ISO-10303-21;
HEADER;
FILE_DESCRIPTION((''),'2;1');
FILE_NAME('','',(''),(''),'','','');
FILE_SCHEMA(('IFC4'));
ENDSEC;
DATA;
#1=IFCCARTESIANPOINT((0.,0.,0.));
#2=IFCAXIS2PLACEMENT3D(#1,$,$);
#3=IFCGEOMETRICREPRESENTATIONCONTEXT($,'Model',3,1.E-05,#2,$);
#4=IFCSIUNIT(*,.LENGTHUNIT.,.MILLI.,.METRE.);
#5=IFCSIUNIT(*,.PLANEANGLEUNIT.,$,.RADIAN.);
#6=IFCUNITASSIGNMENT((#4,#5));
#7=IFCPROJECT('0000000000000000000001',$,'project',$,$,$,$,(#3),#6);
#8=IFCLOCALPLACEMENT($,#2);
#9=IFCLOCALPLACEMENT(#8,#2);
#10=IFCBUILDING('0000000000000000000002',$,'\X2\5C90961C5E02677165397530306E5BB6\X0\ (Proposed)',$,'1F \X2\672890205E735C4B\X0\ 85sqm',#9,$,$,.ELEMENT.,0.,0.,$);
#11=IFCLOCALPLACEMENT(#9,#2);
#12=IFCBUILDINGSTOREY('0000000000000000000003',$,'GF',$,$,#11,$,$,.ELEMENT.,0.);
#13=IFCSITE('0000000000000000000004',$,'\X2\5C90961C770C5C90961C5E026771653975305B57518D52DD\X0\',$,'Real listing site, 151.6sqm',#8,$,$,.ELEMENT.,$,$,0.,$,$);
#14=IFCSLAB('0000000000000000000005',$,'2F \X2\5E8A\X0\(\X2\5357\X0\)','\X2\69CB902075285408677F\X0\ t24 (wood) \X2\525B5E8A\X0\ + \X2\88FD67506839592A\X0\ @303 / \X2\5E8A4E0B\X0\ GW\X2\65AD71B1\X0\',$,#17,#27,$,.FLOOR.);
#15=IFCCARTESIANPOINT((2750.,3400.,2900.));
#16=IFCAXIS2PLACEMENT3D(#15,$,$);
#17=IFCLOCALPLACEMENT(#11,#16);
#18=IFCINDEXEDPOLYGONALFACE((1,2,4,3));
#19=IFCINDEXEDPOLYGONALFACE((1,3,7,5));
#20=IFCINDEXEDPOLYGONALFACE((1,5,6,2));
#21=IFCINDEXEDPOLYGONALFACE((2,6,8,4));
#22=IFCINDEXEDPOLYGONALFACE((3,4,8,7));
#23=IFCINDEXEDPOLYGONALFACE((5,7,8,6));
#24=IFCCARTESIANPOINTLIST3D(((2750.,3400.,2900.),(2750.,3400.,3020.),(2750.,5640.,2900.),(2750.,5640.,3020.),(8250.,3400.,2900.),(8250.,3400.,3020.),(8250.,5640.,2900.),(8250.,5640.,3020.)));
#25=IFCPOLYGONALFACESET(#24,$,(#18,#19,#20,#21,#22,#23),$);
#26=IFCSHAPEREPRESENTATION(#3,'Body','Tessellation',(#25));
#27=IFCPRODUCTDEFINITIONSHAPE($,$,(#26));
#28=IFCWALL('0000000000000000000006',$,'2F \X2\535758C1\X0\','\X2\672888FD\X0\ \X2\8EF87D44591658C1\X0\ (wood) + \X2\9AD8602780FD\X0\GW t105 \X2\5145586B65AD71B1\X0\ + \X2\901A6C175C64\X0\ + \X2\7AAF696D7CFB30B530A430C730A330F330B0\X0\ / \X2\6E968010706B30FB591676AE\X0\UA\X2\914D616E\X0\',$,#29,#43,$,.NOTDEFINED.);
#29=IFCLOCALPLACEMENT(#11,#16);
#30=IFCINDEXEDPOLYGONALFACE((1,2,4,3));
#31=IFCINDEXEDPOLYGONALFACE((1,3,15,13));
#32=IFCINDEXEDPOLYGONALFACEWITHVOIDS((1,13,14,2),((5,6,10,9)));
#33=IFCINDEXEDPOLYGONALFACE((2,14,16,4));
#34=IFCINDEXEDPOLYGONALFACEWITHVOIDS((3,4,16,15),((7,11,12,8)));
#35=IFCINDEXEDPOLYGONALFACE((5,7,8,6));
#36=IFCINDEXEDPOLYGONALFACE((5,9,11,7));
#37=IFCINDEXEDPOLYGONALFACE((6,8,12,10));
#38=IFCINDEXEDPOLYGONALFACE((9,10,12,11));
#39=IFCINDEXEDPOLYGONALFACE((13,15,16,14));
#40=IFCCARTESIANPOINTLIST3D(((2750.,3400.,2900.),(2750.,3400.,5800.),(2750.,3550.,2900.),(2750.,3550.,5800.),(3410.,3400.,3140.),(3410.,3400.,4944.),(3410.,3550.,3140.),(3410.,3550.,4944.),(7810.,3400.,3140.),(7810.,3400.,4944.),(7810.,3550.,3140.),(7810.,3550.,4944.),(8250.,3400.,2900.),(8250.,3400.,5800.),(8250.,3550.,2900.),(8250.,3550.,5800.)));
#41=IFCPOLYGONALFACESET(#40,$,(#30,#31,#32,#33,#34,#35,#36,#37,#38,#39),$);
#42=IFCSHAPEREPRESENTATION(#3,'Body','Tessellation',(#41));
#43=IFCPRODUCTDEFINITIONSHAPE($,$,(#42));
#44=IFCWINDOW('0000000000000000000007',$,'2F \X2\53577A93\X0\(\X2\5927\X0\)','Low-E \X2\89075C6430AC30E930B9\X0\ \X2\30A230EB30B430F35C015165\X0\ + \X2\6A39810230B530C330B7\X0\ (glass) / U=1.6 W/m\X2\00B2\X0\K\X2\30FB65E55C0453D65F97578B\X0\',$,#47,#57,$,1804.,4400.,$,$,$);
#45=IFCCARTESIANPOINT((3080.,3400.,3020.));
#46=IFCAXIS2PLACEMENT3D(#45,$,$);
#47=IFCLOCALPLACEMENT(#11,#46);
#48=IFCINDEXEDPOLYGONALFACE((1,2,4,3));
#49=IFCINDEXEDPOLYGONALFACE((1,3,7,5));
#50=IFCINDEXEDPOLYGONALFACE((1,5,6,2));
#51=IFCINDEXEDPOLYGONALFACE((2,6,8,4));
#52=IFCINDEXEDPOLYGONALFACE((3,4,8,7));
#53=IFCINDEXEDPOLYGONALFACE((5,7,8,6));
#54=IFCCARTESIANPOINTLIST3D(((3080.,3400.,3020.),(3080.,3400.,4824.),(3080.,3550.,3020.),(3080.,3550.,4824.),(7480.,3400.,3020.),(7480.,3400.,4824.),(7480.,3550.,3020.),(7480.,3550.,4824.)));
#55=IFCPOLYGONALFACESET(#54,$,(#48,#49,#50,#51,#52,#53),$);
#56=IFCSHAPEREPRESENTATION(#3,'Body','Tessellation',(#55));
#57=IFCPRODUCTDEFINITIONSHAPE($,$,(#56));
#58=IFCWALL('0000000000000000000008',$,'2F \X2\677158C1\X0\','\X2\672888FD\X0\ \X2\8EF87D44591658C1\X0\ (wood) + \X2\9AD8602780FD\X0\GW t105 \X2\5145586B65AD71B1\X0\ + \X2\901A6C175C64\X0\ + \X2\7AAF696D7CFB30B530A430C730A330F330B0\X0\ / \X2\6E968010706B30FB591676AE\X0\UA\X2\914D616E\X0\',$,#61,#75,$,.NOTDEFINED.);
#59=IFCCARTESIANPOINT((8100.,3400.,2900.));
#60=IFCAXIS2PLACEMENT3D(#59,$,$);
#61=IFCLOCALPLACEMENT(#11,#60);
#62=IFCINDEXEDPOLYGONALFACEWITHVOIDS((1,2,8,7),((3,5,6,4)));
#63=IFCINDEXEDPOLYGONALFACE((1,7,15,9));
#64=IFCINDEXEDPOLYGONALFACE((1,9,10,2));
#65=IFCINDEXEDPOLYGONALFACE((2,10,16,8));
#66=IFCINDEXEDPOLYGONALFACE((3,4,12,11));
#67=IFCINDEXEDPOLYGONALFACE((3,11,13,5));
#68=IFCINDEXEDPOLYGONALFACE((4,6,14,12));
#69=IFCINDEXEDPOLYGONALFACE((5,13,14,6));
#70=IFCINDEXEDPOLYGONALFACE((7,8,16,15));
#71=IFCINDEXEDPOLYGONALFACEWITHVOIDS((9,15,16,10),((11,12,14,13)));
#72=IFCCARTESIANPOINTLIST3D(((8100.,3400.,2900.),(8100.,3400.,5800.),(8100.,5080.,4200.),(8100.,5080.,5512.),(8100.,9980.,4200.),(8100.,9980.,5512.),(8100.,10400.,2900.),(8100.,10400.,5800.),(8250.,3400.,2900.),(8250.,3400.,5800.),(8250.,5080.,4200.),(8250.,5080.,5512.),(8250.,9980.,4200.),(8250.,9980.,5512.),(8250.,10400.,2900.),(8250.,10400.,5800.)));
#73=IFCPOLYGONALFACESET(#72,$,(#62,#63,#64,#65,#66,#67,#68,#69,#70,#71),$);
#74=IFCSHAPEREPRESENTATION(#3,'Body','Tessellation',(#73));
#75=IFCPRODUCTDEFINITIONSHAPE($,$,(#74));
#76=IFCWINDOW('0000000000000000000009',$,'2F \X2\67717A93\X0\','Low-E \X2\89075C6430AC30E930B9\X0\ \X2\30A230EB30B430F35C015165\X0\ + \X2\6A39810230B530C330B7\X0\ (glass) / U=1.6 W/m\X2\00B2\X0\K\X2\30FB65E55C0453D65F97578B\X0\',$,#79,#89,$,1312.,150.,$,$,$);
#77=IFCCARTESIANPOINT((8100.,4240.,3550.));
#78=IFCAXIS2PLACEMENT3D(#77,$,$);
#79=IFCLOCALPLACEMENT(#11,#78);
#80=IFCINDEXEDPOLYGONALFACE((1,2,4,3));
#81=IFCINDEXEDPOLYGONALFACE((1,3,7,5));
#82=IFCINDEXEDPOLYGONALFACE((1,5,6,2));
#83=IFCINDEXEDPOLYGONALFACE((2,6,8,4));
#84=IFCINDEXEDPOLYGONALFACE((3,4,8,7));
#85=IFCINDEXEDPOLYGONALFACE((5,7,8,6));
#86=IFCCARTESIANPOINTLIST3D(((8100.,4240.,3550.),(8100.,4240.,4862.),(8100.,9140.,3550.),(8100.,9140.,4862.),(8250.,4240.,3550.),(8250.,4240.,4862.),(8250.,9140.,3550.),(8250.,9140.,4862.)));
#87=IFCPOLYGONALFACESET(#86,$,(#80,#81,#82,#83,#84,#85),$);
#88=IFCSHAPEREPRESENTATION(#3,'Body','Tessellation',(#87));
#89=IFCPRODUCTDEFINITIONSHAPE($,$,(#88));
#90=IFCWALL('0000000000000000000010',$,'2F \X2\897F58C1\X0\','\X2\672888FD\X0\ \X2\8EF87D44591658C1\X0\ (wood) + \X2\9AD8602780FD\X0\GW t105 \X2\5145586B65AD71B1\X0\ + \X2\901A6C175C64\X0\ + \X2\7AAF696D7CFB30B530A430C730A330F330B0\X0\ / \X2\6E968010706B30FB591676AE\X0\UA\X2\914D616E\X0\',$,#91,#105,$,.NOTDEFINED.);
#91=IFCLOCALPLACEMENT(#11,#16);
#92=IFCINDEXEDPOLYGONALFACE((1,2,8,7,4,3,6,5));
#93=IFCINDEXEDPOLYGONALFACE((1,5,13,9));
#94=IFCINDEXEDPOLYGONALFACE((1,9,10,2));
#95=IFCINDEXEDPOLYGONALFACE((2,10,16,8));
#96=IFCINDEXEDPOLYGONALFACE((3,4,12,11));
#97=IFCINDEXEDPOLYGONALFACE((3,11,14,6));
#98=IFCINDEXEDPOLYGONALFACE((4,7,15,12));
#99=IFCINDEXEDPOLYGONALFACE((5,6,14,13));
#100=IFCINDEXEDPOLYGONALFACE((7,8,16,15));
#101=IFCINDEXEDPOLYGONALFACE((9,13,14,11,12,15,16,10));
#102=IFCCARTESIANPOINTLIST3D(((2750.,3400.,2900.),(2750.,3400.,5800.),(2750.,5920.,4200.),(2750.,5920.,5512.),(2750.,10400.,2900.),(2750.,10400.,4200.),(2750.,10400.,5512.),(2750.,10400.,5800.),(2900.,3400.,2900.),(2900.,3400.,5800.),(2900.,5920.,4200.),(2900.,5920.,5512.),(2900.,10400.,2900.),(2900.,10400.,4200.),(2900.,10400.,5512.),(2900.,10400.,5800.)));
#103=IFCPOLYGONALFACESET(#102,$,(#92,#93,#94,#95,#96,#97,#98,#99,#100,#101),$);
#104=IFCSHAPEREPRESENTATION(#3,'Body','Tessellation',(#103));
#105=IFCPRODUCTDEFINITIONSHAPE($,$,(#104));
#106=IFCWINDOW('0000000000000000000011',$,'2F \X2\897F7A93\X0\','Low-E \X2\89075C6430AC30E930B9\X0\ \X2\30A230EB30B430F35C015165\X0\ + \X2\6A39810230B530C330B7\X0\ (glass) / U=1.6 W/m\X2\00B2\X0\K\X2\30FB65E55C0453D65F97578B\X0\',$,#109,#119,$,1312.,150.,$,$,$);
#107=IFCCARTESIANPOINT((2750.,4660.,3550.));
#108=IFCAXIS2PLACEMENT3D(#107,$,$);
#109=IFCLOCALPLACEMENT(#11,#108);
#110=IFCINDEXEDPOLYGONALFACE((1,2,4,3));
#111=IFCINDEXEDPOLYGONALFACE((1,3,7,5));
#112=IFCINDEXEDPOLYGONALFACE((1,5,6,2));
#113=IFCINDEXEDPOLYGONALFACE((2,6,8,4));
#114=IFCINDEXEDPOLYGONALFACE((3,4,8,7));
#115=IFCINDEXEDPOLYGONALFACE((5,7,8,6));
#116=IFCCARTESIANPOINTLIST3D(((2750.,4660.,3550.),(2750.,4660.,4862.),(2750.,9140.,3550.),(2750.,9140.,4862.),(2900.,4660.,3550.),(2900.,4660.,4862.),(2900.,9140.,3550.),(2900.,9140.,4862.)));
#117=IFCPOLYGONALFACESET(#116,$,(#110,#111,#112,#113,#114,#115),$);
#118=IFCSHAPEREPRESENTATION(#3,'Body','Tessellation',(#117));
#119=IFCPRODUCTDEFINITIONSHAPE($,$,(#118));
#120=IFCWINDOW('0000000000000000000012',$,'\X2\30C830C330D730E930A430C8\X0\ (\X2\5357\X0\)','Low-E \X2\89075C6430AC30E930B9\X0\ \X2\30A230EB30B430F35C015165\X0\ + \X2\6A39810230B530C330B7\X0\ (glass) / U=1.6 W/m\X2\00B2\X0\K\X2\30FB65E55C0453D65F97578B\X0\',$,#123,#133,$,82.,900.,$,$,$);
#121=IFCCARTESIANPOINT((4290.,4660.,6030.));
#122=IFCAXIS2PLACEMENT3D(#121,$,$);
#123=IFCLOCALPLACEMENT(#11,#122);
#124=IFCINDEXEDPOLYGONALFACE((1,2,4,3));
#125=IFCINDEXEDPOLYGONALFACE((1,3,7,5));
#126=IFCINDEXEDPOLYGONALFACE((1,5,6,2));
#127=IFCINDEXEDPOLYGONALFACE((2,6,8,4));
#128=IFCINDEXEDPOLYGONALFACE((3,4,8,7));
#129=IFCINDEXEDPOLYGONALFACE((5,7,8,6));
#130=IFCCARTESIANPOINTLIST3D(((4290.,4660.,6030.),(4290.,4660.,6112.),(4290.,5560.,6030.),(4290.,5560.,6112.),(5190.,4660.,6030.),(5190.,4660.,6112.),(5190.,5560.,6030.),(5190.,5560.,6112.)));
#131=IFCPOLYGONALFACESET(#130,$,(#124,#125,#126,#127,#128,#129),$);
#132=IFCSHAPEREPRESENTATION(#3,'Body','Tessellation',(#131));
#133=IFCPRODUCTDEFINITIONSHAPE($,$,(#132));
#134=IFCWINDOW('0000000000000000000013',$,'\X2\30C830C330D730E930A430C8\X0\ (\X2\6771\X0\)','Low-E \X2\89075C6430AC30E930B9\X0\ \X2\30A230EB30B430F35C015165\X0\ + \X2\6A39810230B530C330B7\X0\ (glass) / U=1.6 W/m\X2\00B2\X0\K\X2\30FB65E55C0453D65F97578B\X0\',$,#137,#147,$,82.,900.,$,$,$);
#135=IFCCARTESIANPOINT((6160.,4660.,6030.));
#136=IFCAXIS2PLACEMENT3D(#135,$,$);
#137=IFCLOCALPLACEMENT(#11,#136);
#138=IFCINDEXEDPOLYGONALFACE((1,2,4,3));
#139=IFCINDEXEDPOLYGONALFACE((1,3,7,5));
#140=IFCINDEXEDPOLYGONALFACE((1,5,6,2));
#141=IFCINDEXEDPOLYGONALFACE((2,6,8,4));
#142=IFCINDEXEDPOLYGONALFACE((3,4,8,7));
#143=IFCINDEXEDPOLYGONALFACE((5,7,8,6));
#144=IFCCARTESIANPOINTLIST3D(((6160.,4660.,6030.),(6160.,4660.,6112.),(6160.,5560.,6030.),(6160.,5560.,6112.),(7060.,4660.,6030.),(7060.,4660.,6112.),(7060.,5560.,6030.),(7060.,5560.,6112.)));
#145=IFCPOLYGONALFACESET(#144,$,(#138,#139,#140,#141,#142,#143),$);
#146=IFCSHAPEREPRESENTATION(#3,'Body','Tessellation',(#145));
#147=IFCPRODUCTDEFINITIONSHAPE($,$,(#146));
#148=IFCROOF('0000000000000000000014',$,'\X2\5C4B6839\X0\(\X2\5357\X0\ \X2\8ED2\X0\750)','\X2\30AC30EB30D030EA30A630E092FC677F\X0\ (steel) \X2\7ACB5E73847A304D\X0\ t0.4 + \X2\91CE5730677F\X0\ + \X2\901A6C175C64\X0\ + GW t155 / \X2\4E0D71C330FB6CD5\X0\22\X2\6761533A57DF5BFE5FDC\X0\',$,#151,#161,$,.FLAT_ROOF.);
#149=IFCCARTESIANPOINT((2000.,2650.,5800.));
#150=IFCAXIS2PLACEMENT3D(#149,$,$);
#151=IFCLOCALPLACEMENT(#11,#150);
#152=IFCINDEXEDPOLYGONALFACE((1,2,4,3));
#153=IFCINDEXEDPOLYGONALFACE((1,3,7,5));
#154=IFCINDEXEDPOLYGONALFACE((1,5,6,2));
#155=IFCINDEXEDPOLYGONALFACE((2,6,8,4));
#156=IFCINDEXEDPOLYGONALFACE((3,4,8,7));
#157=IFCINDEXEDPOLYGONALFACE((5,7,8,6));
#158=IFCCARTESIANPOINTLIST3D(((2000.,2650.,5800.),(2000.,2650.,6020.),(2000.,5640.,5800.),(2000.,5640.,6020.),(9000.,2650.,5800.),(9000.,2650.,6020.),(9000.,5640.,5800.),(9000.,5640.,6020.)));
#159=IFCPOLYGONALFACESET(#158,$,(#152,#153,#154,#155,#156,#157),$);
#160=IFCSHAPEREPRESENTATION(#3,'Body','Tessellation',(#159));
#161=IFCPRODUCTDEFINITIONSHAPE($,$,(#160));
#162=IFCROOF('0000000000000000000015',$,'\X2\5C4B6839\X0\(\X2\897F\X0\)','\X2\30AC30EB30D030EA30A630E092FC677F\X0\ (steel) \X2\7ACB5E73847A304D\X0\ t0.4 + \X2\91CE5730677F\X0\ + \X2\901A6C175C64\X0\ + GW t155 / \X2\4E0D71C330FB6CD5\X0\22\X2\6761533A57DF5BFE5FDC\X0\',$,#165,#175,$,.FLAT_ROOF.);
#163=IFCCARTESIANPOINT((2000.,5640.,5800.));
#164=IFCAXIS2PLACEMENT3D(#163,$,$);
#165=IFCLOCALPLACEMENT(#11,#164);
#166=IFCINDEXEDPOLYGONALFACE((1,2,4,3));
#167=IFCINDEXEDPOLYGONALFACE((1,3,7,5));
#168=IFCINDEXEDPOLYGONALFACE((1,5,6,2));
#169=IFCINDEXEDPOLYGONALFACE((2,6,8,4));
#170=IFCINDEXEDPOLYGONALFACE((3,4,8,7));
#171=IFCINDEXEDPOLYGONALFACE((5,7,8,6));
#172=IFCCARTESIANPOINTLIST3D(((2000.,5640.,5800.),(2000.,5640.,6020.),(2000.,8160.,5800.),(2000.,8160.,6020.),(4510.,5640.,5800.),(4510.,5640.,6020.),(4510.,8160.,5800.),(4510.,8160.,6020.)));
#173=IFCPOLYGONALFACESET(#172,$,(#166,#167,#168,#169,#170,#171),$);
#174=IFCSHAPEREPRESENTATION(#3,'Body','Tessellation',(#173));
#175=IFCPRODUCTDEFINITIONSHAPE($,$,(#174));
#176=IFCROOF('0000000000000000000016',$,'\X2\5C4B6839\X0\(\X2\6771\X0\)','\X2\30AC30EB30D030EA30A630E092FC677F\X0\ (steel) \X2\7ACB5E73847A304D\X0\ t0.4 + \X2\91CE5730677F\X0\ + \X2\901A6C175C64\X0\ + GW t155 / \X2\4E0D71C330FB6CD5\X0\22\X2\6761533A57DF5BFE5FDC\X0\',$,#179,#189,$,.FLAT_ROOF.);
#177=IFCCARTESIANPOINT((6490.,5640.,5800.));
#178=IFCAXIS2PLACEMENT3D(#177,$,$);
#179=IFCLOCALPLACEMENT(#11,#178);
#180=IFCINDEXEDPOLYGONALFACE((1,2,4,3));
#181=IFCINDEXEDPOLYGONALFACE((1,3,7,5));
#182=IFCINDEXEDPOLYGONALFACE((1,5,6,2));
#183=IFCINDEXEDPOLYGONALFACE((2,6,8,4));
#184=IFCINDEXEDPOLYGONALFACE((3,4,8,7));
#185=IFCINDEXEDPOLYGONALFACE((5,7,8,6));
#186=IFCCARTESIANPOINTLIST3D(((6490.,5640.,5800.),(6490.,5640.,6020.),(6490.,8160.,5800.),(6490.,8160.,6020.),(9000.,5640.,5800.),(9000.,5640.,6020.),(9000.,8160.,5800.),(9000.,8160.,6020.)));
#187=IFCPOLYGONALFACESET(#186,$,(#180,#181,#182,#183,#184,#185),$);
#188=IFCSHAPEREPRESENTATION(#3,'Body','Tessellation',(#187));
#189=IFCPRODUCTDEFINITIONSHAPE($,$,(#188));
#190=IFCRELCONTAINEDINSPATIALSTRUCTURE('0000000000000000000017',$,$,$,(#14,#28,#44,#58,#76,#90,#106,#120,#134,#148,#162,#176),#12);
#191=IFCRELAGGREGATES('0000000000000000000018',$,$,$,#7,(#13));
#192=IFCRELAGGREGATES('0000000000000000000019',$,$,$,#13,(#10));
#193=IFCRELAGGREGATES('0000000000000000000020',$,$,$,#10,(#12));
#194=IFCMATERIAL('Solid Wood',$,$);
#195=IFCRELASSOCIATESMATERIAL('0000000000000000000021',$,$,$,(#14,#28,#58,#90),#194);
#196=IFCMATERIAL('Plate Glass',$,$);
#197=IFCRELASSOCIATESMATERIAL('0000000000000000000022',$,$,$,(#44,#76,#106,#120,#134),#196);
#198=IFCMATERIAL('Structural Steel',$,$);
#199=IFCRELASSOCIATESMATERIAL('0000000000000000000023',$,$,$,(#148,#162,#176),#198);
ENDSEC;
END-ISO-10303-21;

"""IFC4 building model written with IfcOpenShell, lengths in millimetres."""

from ifc_helpers import new_model, si_unit, frame, frame_2d, origin, place, context, project, spatial, rectangle, extrude, material, element, fill, save


model = new_model("IFC4")

# Units and contexts
model_context = context("Model", 3, precision=1e-05, world=origin())
ifc_project = project(units=[si_unit("LENGTHUNIT", "METRE", prefix="MILLI"), si_unit("PLANEANGLEUNIT", "RADIAN")], contexts=[model_context])

# Site, building, storey
site_placement = place(None, origin())
site = spatial("IfcSite", under=ifc_project, at=site_placement, Name="岐阜県岐阜市東改田字再勝", ObjectType="Real listing site, 151.6sqm", CompositionType="ELEMENT", RefElevation=0.0)
building_placement = place(site_placement, origin())
building = spatial("IfcBuilding", under=site, at=building_placement, Name="岐阜市東改田の家 (Proposed)", ObjectType="1F 木造平屋 85sqm", CompositionType="ELEMENT", ElevationOfRefHeight=0.0, ElevationOfTerrain=0.0)
storey_placement = place(building_placement, origin())
storey = spatial("IfcBuildingStorey", under=building, at=storey_placement, Name="GF", CompositionType="ELEMENT", Elevation=0.0)

# Slab
ifc_material_1 = material(Name="Solid Wood")
slab_placement = place(storey_placement, frame((2750.0, 3400.0, 2900.0)))
element("IfcSlab", 1, at=slab_placement, inside=storey, material=ifc_material_1, Name="2F 床(南)", Description="構造用合板 t24 (wood) 剛床 + 製材根太 @303 / 床下 GW断熱", PredefinedType="FLOOR", context=model_context, shape_type="SweptSolid", body=[
    extrude(rectangle(XDim=5500.0, YDim=2240.0, at=frame_2d((2750.0, 1120.0))), frame((2750.0, 3400.0, 2900.0)), (0.0, 0.0, 1.0), 120.0),
])

# Walls, openings, windows
wall_1_placement = place(storey_placement, frame((2750.0, 3400.0, 2900.0)))
wall_1 = element("IfcWall", 2, at=wall_1_placement, inside=storey, material=ifc_material_1, Name="2F 南壁", Description="木製 軸組外壁 (wood) + 高性能GW t105 充填断熱 + 通気層 + 窯業系サイディング / 準耐火・外皮UA配慮", PredefinedType="NOTDEFINED", context=model_context, shape_type="SweptSolid", body=[
    extrude(rectangle(XDim=5500.0, YDim=150.0, at=frame_2d((2750.0, 75.0))), frame((2750.0, 3400.0, 2900.0)), (0.0, 0.0, 1.0), 2900.0),
])
opening_1_placement = place(storey_placement, frame((3080.0, 3400.0, 3020.0)))
opening_1 = element("IfcOpeningElement", 3, at=opening_1_placement, cuts=wall_1, PredefinedType="NOTDEFINED", context=model_context, shape_type="SweptSolid", body=[
    extrude(rectangle(XDim=4400.0, YDim=150.0, at=frame_2d((2200.0, 75.0))), frame((3080.0, 3400.0, 3020.0)), (0.0, 0.0, 1.0), 1804.0),
])
ifc_material_2 = material(Name="Plate Glass")
window_1_placement = place(storey_placement, frame((3080.0, 3400.0, 3020.0)))
window_1 = element("IfcWindow", 4, at=window_1_placement, inside=storey, material=ifc_material_2, Name="2F 南窓(大)", Description="Low-E 複層ガラス アルゴン封入 + 樹脂サッシ (glass) / U=1.6 W/m²K・日射取得型", OverallHeight=1804.0, OverallWidth=4400.0, context=model_context, shape_type="SweptSolid", body=[
    extrude(rectangle(XDim=4400.0, YDim=150.0, at=frame_2d((2200.0, 75.0))), frame((3080.0, 3400.0, 3020.0)), (0.0, 0.0, 1.0), 1804.0),
])
fill(opening_1, window_1)
wall_2_placement = place(storey_placement, frame((8100.0, 3400.0, 2900.0)))
wall_2 = element("IfcWall", 5, at=wall_2_placement, inside=storey, material=ifc_material_1, Name="2F 東壁", Description="木製 軸組外壁 (wood) + 高性能GW t105 充填断熱 + 通気層 + 窯業系サイディング / 準耐火・外皮UA配慮", PredefinedType="NOTDEFINED", context=model_context, shape_type="SweptSolid", body=[
    extrude(rectangle(XDim=150.0, YDim=7000.0, at=frame_2d((75.0, 3500.0))), frame((8100.0, 3400.0, 2900.0)), (0.0, 0.0, 1.0), 2900.0),
])
opening_2_placement = place(storey_placement, frame((8100.0, 4240.0, 3550.0)))
opening_2 = element("IfcOpeningElement", 6, at=opening_2_placement, cuts=wall_2, PredefinedType="NOTDEFINED", context=model_context, shape_type="SweptSolid", body=[
    extrude(rectangle(XDim=150.0, YDim=4900.0, at=frame_2d((75.0, 2450.0))), frame((8100.0, 4240.0, 3550.0)), (0.0, 0.0, 1.0), 1312.0),
])
window_2_placement = place(storey_placement, frame((8100.0, 4240.0, 3550.0)))
window_2 = element("IfcWindow", 7, at=window_2_placement, inside=storey, material=ifc_material_2, Name="2F 東窓", Description="Low-E 複層ガラス アルゴン封入 + 樹脂サッシ (glass) / U=1.6 W/m²K・日射取得型", OverallHeight=1312.0, OverallWidth=150.0, context=model_context, shape_type="SweptSolid", body=[
    extrude(rectangle(XDim=150.0, YDim=4900.0, at=frame_2d((75.0, 2450.0))), frame((8100.0, 4240.0, 3550.0)), (0.0, 0.0, 1.0), 1312.0),
])
fill(opening_2, window_2)
wall_3_placement = place(storey_placement, frame((2750.0, 3400.0, 2900.0)))
wall_3 = element("IfcWall", 8, at=wall_3_placement, inside=storey, material=ifc_material_1, Name="2F 西壁", Description="木製 軸組外壁 (wood) + 高性能GW t105 充填断熱 + 通気層 + 窯業系サイディング / 準耐火・外皮UA配慮", PredefinedType="NOTDEFINED", context=model_context, shape_type="SweptSolid", body=[
    extrude(rectangle(XDim=150.0, YDim=7000.0, at=frame_2d((75.0, 3500.0))), frame((2750.0, 3400.0, 2900.0)), (0.0, 0.0, 1.0), 2900.0),
])
opening_3_placement = place(storey_placement, frame((2750.0, 4660.0, 3550.0)))
opening_3 = element("IfcOpeningElement", 9, at=opening_3_placement, cuts=wall_3, PredefinedType="NOTDEFINED", context=model_context, shape_type="SweptSolid", body=[
    extrude(rectangle(XDim=150.0, YDim=4480.0, at=frame_2d((75.0, 2240.0))), frame((2750.0, 4660.0, 3550.0)), (0.0, 0.0, 1.0), 1312.0),
])
window_3_placement = place(storey_placement, frame((2750.0, 4660.0, 3550.0)))
window_3 = element("IfcWindow", 10, at=window_3_placement, inside=storey, material=ifc_material_2, Name="2F 西窓", Description="Low-E 複層ガラス アルゴン封入 + 樹脂サッシ (glass) / U=1.6 W/m²K・日射取得型", OverallHeight=1312.0, OverallWidth=150.0, context=model_context, shape_type="SweptSolid", body=[
    extrude(rectangle(XDim=150.0, YDim=4480.0, at=frame_2d((75.0, 2240.0))), frame((2750.0, 4660.0, 3550.0)), (0.0, 0.0, 1.0), 1312.0),
])
fill(opening_3, window_3)

# Windows
window_4_placement = place(storey_placement, frame((4290.0, 4660.0, 6030.0)))
element("IfcWindow", 11, at=window_4_placement, inside=storey, material=ifc_material_2, Name="トップライト (南)", Description="Low-E 複層ガラス アルゴン封入 + 樹脂サッシ (glass) / U=1.6 W/m²K・日射取得型", OverallHeight=82.0, OverallWidth=900.0, context=model_context, shape_type="SweptSolid", body=[
    extrude(rectangle(XDim=900.0, YDim=900.0, at=frame_2d((450.0, 450.0))), frame((4290.0, 4660.0, 6030.0)), (0.0, 0.0, 1.0), 82.0),
])
window_5_placement = place(storey_placement, frame((6160.0, 4660.0, 6030.0)))
element("IfcWindow", 12, at=window_5_placement, inside=storey, material=ifc_material_2, Name="トップライト (東)", Description="Low-E 複層ガラス アルゴン封入 + 樹脂サッシ (glass) / U=1.6 W/m²K・日射取得型", OverallHeight=82.0, OverallWidth=900.0, context=model_context, shape_type="SweptSolid", body=[
    extrude(rectangle(XDim=900.0, YDim=900.0, at=frame_2d((450.0, 450.0))), frame((6160.0, 4660.0, 6030.0)), (0.0, 0.0, 1.0), 82.0),
])

# Roofs
ifc_material_3 = material(Name="Structural Steel")
roof_1_placement = place(storey_placement, frame((2000.0, 2650.0, 5800.0)))
element("IfcRoof", 13, at=roof_1_placement, inside=storey, material=ifc_material_3, Name="屋根(南 軒750)", Description="ガルバリウム鋼板 (steel) 立平葺き t0.4 + 野地板 + 通気層 + GW t155 / 不燃・法22条区域対応", PredefinedType="FLAT_ROOF", context=model_context, shape_type="SweptSolid", body=[
    extrude(rectangle(XDim=7000.0, YDim=2990.0, at=frame_2d((3500.0, 1495.0))), frame((2000.0, 2650.0, 5800.0)), (0.0, 0.0, 1.0), 220.0),
])
roof_2_placement = place(storey_placement, frame((2000.0, 5640.0, 5800.0)))
element("IfcRoof", 14, at=roof_2_placement, inside=storey, material=ifc_material_3, Name="屋根(西)", Description="ガルバリウム鋼板 (steel) 立平葺き t0.4 + 野地板 + 通気層 + GW t155 / 不燃・法22条区域対応", PredefinedType="FLAT_ROOF", context=model_context, shape_type="SweptSolid", body=[
    extrude(rectangle(XDim=2510.0, YDim=2520.0, at=frame_2d((1255.0, 1260.0))), frame((2000.0, 5640.0, 5800.0)), (0.0, 0.0, 1.0), 220.0),
])
roof_3_placement = place(storey_placement, frame((6490.0, 5640.0, 5800.0)))
element("IfcRoof", 15, at=roof_3_placement, inside=storey, material=ifc_material_3, Name="屋根(東)", Description="ガルバリウム鋼板 (steel) 立平葺き t0.4 + 野地板 + 通気層 + GW t155 / 不燃・法22条区域対応", PredefinedType="FLAT_ROOF", context=model_context, shape_type="SweptSolid", body=[
    extrude(rectangle(XDim=2510.0, YDim=2520.0, at=frame_2d((1255.0, 1260.0))), frame((6490.0, 5640.0, 5800.0)), (0.0, 0.0, 1.0), 220.0),
])

save(model, "model.ifc")
